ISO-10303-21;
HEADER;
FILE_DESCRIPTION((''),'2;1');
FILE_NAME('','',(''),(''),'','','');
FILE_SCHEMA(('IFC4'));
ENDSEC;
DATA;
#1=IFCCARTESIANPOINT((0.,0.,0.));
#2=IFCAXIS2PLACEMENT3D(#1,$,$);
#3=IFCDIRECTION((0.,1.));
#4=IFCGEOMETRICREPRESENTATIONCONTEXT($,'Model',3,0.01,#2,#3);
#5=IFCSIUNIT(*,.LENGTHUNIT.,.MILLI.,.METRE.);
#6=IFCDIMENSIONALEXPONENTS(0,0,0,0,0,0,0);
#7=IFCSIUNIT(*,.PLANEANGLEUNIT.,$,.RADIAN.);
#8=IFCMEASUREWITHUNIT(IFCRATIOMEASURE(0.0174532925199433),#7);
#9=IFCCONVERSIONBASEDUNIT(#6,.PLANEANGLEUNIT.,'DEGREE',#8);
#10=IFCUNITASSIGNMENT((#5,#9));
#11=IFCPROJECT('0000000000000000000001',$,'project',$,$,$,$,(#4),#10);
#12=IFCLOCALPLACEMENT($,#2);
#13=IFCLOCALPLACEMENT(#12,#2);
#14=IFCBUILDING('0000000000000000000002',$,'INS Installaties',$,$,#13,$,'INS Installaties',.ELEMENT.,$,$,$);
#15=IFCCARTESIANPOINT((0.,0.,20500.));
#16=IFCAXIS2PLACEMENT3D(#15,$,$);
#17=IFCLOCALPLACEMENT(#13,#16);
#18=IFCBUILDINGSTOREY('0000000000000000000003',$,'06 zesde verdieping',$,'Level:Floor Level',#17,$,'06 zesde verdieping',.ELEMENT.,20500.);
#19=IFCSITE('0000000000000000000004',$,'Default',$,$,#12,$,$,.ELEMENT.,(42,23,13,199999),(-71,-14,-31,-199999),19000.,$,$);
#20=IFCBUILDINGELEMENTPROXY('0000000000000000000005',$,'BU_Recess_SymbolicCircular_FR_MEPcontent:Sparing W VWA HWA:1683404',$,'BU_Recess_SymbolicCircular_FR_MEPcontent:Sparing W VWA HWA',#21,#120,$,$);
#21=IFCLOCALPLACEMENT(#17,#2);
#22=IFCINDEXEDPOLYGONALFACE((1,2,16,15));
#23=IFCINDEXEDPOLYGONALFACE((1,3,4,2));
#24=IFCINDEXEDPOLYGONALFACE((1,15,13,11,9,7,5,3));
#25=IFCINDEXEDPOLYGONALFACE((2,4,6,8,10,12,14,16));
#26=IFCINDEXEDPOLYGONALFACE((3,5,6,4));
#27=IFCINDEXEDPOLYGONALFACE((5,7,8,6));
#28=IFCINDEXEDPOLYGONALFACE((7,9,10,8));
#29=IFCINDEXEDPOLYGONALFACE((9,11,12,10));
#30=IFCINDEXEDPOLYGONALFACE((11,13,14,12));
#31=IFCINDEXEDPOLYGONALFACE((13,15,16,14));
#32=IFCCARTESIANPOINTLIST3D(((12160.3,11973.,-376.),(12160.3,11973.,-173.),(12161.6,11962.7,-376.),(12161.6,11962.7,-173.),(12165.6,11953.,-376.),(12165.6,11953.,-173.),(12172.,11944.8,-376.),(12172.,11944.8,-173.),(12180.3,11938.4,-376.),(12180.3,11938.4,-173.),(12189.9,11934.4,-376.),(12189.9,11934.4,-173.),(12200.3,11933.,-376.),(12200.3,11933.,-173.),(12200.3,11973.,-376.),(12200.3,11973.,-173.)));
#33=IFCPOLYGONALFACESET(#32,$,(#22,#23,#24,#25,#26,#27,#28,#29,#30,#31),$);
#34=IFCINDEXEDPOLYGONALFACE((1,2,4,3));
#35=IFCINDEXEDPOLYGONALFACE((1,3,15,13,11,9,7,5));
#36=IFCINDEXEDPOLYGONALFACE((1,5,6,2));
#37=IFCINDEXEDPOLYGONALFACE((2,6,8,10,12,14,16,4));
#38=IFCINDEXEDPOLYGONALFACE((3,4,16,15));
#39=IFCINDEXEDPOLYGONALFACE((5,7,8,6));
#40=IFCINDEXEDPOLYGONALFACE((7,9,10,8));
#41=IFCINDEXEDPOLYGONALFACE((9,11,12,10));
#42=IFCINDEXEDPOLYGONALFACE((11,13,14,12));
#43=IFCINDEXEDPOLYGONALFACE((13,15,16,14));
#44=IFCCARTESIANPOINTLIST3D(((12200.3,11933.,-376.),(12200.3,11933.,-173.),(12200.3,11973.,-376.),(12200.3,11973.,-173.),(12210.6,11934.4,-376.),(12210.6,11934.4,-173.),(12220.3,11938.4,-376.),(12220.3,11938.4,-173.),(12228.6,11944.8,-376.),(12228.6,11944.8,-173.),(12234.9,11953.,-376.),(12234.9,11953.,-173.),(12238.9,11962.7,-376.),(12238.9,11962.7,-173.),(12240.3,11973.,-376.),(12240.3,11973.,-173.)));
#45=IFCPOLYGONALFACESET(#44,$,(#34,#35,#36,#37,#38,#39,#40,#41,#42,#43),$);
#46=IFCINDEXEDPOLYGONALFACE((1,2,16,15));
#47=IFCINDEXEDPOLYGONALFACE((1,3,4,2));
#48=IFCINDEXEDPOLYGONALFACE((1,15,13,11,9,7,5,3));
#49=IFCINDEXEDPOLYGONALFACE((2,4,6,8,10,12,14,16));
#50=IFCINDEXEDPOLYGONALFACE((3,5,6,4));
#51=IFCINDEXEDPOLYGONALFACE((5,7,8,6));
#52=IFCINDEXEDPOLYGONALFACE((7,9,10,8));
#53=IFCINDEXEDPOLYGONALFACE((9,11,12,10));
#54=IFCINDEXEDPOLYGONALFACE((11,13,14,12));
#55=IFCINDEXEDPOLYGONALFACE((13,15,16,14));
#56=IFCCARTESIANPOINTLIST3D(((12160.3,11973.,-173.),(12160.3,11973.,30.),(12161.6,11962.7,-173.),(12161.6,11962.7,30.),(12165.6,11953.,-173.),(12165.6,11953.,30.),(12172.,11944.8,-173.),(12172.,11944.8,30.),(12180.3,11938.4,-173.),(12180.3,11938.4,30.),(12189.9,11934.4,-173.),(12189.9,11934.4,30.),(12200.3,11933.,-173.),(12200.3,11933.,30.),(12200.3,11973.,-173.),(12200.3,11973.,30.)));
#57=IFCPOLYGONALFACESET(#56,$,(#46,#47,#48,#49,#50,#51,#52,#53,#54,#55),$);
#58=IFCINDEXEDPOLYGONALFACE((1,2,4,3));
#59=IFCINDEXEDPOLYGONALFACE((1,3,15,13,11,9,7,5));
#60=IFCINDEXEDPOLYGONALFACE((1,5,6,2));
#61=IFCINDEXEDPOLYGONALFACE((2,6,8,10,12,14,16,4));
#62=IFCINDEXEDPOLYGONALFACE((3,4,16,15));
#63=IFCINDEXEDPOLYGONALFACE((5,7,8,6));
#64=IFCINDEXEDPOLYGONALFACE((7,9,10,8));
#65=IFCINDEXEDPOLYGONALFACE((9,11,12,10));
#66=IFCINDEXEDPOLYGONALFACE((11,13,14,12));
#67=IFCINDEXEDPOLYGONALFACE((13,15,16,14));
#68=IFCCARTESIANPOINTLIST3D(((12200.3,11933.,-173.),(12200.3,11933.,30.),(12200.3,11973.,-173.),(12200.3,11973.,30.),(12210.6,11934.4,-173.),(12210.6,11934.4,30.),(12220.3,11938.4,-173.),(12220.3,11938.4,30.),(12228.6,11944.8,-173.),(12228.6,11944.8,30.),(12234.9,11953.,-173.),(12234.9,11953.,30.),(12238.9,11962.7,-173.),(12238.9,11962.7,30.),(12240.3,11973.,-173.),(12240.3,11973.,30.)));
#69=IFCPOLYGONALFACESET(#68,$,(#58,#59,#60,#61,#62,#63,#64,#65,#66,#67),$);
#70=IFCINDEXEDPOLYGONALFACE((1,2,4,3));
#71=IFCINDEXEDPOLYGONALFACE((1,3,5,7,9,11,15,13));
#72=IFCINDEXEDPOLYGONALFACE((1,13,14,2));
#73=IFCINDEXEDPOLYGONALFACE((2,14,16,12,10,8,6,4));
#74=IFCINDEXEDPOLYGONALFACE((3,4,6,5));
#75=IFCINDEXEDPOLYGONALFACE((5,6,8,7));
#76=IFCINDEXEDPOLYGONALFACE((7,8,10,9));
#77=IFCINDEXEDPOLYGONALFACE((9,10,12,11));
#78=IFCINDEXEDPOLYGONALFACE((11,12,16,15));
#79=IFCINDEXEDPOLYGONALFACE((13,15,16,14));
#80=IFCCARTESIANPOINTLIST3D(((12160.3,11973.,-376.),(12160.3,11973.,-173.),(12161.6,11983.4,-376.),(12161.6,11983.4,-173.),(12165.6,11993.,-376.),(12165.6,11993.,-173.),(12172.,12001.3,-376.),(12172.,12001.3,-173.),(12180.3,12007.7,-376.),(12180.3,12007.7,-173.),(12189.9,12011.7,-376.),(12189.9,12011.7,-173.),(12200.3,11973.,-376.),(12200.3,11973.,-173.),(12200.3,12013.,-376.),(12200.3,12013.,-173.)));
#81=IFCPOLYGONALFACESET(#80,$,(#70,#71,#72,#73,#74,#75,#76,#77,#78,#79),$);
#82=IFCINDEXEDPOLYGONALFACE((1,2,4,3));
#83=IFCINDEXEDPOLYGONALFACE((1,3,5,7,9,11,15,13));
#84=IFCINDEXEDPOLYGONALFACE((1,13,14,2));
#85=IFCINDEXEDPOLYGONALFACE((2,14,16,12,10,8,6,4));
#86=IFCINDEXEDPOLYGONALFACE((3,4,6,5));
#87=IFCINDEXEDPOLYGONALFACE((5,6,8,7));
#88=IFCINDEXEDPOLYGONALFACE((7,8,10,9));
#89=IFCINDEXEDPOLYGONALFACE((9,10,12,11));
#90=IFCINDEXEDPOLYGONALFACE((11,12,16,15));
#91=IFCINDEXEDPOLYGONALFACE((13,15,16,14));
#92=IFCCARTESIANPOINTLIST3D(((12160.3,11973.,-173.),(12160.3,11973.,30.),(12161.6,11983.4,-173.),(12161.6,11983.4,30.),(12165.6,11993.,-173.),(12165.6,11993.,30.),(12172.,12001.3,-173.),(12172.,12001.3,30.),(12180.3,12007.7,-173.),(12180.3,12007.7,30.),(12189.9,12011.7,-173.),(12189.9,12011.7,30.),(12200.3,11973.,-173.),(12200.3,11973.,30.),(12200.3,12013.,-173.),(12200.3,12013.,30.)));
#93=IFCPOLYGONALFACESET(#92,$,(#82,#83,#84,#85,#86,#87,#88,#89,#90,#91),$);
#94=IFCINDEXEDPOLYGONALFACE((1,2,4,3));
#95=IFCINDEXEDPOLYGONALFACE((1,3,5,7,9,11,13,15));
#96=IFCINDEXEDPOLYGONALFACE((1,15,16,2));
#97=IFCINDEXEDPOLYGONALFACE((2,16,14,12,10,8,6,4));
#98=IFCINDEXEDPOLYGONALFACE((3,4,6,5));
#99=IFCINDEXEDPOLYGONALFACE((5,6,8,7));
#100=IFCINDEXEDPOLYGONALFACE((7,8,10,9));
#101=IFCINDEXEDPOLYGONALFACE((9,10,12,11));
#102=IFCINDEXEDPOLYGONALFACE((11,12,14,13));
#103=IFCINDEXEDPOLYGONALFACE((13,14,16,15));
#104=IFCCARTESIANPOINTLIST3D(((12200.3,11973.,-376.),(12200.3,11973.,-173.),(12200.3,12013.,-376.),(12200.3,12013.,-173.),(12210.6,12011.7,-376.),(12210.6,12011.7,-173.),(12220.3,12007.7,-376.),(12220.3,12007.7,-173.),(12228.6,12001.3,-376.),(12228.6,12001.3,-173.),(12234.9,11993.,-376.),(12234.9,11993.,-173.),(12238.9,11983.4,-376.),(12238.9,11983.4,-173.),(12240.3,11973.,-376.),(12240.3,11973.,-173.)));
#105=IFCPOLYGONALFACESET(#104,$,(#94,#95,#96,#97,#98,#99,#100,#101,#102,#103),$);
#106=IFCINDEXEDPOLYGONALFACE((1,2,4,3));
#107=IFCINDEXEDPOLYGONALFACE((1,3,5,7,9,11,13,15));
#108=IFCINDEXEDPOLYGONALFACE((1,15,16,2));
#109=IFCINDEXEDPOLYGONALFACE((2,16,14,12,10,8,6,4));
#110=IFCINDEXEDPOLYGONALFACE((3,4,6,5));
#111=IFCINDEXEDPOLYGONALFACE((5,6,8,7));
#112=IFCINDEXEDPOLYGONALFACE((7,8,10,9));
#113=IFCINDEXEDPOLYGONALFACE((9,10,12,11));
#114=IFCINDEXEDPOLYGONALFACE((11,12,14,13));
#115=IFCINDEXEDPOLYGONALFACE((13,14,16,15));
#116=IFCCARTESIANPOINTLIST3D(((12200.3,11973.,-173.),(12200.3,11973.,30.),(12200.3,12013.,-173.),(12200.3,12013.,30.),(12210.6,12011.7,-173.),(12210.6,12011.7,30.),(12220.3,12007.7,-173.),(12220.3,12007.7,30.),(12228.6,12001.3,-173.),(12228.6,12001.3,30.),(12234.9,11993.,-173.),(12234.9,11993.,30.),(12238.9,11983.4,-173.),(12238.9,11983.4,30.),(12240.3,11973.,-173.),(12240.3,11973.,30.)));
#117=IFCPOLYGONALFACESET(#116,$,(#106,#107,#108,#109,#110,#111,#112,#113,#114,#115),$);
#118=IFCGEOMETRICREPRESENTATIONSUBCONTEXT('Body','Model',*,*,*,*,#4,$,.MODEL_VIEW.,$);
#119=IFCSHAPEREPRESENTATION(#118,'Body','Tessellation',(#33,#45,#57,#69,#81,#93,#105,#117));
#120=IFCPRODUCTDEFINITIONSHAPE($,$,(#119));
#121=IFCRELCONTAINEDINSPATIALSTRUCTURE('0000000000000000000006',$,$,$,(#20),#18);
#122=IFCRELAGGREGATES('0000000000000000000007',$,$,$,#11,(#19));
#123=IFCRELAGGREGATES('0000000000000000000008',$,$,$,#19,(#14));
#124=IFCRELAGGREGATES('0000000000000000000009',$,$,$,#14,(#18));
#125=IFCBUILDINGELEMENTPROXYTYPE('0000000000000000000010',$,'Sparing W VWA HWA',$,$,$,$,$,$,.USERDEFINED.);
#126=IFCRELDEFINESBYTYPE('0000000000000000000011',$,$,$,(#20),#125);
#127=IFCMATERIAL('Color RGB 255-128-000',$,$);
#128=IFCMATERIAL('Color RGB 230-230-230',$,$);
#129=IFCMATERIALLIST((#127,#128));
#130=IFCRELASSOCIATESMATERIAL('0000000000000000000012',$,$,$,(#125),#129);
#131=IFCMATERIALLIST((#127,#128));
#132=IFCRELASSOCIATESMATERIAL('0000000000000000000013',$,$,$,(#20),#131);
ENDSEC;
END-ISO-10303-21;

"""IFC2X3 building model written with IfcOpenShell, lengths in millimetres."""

from ifc_helpers import new_model, entity, si_unit, converted_unit, direction, frame, frame_2d, origin, place, context, subcontext, project, spatial, polyline, circle_curve, parameter, trimmed, segment, composite_curve, outline, extrude, source, transform, mapped, material, material_list, type_object, type_shapes, element, save


model = new_model("IFC2X3")

# Units and contexts
model_context = context("Model", 3, precision=0.01, world=origin(), true_north=direction((0.0, 1.0)))
body_context = subcontext(model_context, "Body", "Model", "MODEL_VIEW")
ifc_project = project(units=[si_unit("LENGTHUNIT", "METRE", prefix="MILLI"), converted_unit("PLANEANGLEUNIT", "DEGREE", entity("IfcRatioMeasure", 0.0174532925199433), si_unit("PLANEANGLEUNIT", "RADIAN"), dimensions=[0, 0, 0, 0, 0, 0, 0])], contexts=[model_context])

# Site, building, storey
site_placement = place(None, origin())
site = spatial("IfcSite", under=ifc_project, at=site_placement, Name="Default", CompositionType="ELEMENT", RefLatitude=(42, 23, 13, 199999), RefLongitude=(-71, -14, -31, -199999), RefElevation=19000.0)
building_placement = place(site_placement, origin())
building = spatial("IfcBuilding", under=site, at=building_placement, Name="INS Installaties", LongName="INS Installaties", CompositionType="ELEMENT")
storey_placement = place(building_placement, frame((0.0, 0.0, 20500.0)))
storey = spatial("IfcBuildingStorey", under=building, at=storey_placement, Name="06 zesde verdieping", ObjectType="Level:Floor Level", LongName="06 zesde verdieping", CompositionType="ELEMENT", Elevation=20500.0)

# Building element proxy
ifc_material_1 = material(Name="Color RGB 255-128-000")
ifc_material_2 = material(Name="Color RGB 230-230-230")
ifc_material_list_1 = material_list([ifc_material_1, ifc_material_2])
building_element_proxy_type_1 = type_object("IfcBuildingElementProxyType", Name="Sparing W VWA HWA", PredefinedType="USERDEFINED", material=ifc_material_list_1)
shared_shape_1 = source(origin(), body_context, "Body", "SweptSolid", [
    extrude(outline(composite_curve([segment(trimmed(circle_curve(frame_2d((13.3, 13.3), x_axis=(1.0, 0.0)), 40.0), [parameter(180.0)], [parameter(270.0)], True, "PARAMETER"), True, "CONTINUOUS"), segment(polyline([(13.3, -26.7), (13.3, 13.3)]), True, "CONTINUOUS"), segment(polyline([(13.3, 13.3), (-26.7, 13.3)]), True, "CONTINUOUS")], self_intersect=False)), frame((13.3, 13.3, -403.0), z_axis=(0.0, 0.0, 1.0), x_axis=(-1.0, 0.0, 0.0)), (0.0, 0.0, 1.0), 203.0),
    extrude(outline(composite_curve([segment(polyline([(-26.7, -13.3), (13.3, -13.3)]), True, "CONTINUOUS"), segment(polyline([(13.3, -13.3), (13.3, 26.7)]), True, "CONTINUOUS"), segment(trimmed(circle_curve(frame_2d((13.3, -13.3), x_axis=(1.0, 0.0)), 40.0), [parameter(90.0)], [parameter(180.0)], True, "PARAMETER"), True, "CONTINUOUS")], self_intersect=False)), frame((-13.3, 13.3, -403.0)), (0.0, 0.0, 1.0), 203.0),
    extrude(outline(composite_curve([segment(trimmed(circle_curve(frame_2d((13.3, 13.3), x_axis=(1.0, 0.0)), 40.0), [parameter(180.0)], [parameter(270.0)], True, "PARAMETER"), True, "CONTINUOUS"), segment(polyline([(13.3, -26.7), (13.3, 13.3)]), True, "CONTINUOUS"), segment(polyline([(13.3, 13.3), (-26.7, 13.3)]), True, "CONTINUOUS")], self_intersect=False)), frame((13.3, 13.3, -200.0), z_axis=(0.0, 0.0, 1.0), x_axis=(-1.0, 0.0, 0.0)), (0.0, 0.0, 1.0), 203.0),
    extrude(outline(composite_curve([segment(polyline([(-26.7, -13.3), (13.3, -13.3)]), True, "CONTINUOUS"), segment(polyline([(13.3, -13.3), (13.3, 26.7)]), True, "CONTINUOUS"), segment(trimmed(circle_curve(frame_2d((13.3, -13.3), x_axis=(1.0, 0.0)), 40.0), [parameter(90.0)], [parameter(180.0)], True, "PARAMETER"), True, "CONTINUOUS")], self_intersect=False)), frame((-13.3, 13.3, -200.0)), (0.0, 0.0, 1.0), 203.0),
    extrude(outline(composite_curve([segment(polyline([(-26.7, -13.3), (13.3, -13.3)]), True, "CONTINUOUS"), segment(polyline([(13.3, -13.3), (13.3, 26.7)]), True, "CONTINUOUS"), segment(trimmed(circle_curve(frame_2d((13.3, -13.3), x_axis=(1.0, 0.0)), 40.0), [parameter(90.0)], [parameter(180.0)], True, "PARAMETER"), True, "CONTINUOUS")], self_intersect=False)), frame((13.3, -13.3, -403.0), z_axis=(0.0, 0.0, 1.0), x_axis=(-1.0, 0.0, 0.0)), (0.0, 0.0, 1.0), 203.0),
    extrude(outline(composite_curve([segment(polyline([(-26.7, -13.3), (13.3, -13.3)]), True, "CONTINUOUS"), segment(polyline([(13.3, -13.3), (13.3, 26.7)]), True, "CONTINUOUS"), segment(trimmed(circle_curve(frame_2d((13.3, -13.3), x_axis=(1.0, 0.0)), 40.0), [parameter(90.0)], [parameter(180.0)], True, "PARAMETER"), True, "CONTINUOUS")], self_intersect=False)), frame((13.3, -13.3, -200.0), z_axis=(0.0, 0.0, 1.0), x_axis=(-1.0, 0.0, 0.0)), (0.0, 0.0, 1.0), 203.0),
    extrude(outline(composite_curve([segment(trimmed(circle_curve(frame_2d((13.3, 13.3), x_axis=(1.0, 0.0)), 40.0), [parameter(180.0)], [parameter(270.0)], True, "PARAMETER"), True, "CONTINUOUS"), segment(polyline([(13.3, -26.7), (13.3, 13.3)]), True, "CONTINUOUS"), segment(polyline([(13.3, 13.3), (-26.7, 13.3)]), True, "CONTINUOUS")], self_intersect=False)), frame((-13.3, -13.3, -403.0)), (0.0, 0.0, 1.0), 203.0),
    extrude(outline(composite_curve([segment(trimmed(circle_curve(frame_2d((13.3, 13.3), x_axis=(1.0, 0.0)), 40.0), [parameter(180.0)], [parameter(270.0)], True, "PARAMETER"), True, "CONTINUOUS"), segment(polyline([(13.3, -26.7), (13.3, 13.3)]), True, "CONTINUOUS"), segment(polyline([(13.3, 13.3), (-26.7, 13.3)]), True, "CONTINUOUS")], self_intersect=False)), frame((-13.3, -13.3, -200.0)), (0.0, 0.0, 1.0), 203.0),
])
type_shapes(building_element_proxy_type_1, [shared_shape_1])
ifc_material_list_2 = material_list([ifc_material_1, ifc_material_2])
proxy_1_placement = place(storey_placement, frame((12200.3, 11973.0, 27.0), z_axis=(0.0, 0.0, 1.0), x_axis=(-1.0, 0.0, 0.0)))
element("IfcBuildingElementProxy", 1, at=proxy_1_placement, inside=storey, type_object=building_element_proxy_type_1, material=ifc_material_list_2, Name="BU_Recess_SymbolicCircular_FR_MEPcontent:Sparing W VWA HWA:1683404", ObjectType="BU_Recess_SymbolicCircular_FR_MEPcontent:Sparing W VWA HWA", context=body_context, shape_type="MappedRepresentation", body=[
    mapped(shared_shape_1, transform((0.0, 0.0, 0.0), scale=1.0)),
])

save(model, "model.ifc")
